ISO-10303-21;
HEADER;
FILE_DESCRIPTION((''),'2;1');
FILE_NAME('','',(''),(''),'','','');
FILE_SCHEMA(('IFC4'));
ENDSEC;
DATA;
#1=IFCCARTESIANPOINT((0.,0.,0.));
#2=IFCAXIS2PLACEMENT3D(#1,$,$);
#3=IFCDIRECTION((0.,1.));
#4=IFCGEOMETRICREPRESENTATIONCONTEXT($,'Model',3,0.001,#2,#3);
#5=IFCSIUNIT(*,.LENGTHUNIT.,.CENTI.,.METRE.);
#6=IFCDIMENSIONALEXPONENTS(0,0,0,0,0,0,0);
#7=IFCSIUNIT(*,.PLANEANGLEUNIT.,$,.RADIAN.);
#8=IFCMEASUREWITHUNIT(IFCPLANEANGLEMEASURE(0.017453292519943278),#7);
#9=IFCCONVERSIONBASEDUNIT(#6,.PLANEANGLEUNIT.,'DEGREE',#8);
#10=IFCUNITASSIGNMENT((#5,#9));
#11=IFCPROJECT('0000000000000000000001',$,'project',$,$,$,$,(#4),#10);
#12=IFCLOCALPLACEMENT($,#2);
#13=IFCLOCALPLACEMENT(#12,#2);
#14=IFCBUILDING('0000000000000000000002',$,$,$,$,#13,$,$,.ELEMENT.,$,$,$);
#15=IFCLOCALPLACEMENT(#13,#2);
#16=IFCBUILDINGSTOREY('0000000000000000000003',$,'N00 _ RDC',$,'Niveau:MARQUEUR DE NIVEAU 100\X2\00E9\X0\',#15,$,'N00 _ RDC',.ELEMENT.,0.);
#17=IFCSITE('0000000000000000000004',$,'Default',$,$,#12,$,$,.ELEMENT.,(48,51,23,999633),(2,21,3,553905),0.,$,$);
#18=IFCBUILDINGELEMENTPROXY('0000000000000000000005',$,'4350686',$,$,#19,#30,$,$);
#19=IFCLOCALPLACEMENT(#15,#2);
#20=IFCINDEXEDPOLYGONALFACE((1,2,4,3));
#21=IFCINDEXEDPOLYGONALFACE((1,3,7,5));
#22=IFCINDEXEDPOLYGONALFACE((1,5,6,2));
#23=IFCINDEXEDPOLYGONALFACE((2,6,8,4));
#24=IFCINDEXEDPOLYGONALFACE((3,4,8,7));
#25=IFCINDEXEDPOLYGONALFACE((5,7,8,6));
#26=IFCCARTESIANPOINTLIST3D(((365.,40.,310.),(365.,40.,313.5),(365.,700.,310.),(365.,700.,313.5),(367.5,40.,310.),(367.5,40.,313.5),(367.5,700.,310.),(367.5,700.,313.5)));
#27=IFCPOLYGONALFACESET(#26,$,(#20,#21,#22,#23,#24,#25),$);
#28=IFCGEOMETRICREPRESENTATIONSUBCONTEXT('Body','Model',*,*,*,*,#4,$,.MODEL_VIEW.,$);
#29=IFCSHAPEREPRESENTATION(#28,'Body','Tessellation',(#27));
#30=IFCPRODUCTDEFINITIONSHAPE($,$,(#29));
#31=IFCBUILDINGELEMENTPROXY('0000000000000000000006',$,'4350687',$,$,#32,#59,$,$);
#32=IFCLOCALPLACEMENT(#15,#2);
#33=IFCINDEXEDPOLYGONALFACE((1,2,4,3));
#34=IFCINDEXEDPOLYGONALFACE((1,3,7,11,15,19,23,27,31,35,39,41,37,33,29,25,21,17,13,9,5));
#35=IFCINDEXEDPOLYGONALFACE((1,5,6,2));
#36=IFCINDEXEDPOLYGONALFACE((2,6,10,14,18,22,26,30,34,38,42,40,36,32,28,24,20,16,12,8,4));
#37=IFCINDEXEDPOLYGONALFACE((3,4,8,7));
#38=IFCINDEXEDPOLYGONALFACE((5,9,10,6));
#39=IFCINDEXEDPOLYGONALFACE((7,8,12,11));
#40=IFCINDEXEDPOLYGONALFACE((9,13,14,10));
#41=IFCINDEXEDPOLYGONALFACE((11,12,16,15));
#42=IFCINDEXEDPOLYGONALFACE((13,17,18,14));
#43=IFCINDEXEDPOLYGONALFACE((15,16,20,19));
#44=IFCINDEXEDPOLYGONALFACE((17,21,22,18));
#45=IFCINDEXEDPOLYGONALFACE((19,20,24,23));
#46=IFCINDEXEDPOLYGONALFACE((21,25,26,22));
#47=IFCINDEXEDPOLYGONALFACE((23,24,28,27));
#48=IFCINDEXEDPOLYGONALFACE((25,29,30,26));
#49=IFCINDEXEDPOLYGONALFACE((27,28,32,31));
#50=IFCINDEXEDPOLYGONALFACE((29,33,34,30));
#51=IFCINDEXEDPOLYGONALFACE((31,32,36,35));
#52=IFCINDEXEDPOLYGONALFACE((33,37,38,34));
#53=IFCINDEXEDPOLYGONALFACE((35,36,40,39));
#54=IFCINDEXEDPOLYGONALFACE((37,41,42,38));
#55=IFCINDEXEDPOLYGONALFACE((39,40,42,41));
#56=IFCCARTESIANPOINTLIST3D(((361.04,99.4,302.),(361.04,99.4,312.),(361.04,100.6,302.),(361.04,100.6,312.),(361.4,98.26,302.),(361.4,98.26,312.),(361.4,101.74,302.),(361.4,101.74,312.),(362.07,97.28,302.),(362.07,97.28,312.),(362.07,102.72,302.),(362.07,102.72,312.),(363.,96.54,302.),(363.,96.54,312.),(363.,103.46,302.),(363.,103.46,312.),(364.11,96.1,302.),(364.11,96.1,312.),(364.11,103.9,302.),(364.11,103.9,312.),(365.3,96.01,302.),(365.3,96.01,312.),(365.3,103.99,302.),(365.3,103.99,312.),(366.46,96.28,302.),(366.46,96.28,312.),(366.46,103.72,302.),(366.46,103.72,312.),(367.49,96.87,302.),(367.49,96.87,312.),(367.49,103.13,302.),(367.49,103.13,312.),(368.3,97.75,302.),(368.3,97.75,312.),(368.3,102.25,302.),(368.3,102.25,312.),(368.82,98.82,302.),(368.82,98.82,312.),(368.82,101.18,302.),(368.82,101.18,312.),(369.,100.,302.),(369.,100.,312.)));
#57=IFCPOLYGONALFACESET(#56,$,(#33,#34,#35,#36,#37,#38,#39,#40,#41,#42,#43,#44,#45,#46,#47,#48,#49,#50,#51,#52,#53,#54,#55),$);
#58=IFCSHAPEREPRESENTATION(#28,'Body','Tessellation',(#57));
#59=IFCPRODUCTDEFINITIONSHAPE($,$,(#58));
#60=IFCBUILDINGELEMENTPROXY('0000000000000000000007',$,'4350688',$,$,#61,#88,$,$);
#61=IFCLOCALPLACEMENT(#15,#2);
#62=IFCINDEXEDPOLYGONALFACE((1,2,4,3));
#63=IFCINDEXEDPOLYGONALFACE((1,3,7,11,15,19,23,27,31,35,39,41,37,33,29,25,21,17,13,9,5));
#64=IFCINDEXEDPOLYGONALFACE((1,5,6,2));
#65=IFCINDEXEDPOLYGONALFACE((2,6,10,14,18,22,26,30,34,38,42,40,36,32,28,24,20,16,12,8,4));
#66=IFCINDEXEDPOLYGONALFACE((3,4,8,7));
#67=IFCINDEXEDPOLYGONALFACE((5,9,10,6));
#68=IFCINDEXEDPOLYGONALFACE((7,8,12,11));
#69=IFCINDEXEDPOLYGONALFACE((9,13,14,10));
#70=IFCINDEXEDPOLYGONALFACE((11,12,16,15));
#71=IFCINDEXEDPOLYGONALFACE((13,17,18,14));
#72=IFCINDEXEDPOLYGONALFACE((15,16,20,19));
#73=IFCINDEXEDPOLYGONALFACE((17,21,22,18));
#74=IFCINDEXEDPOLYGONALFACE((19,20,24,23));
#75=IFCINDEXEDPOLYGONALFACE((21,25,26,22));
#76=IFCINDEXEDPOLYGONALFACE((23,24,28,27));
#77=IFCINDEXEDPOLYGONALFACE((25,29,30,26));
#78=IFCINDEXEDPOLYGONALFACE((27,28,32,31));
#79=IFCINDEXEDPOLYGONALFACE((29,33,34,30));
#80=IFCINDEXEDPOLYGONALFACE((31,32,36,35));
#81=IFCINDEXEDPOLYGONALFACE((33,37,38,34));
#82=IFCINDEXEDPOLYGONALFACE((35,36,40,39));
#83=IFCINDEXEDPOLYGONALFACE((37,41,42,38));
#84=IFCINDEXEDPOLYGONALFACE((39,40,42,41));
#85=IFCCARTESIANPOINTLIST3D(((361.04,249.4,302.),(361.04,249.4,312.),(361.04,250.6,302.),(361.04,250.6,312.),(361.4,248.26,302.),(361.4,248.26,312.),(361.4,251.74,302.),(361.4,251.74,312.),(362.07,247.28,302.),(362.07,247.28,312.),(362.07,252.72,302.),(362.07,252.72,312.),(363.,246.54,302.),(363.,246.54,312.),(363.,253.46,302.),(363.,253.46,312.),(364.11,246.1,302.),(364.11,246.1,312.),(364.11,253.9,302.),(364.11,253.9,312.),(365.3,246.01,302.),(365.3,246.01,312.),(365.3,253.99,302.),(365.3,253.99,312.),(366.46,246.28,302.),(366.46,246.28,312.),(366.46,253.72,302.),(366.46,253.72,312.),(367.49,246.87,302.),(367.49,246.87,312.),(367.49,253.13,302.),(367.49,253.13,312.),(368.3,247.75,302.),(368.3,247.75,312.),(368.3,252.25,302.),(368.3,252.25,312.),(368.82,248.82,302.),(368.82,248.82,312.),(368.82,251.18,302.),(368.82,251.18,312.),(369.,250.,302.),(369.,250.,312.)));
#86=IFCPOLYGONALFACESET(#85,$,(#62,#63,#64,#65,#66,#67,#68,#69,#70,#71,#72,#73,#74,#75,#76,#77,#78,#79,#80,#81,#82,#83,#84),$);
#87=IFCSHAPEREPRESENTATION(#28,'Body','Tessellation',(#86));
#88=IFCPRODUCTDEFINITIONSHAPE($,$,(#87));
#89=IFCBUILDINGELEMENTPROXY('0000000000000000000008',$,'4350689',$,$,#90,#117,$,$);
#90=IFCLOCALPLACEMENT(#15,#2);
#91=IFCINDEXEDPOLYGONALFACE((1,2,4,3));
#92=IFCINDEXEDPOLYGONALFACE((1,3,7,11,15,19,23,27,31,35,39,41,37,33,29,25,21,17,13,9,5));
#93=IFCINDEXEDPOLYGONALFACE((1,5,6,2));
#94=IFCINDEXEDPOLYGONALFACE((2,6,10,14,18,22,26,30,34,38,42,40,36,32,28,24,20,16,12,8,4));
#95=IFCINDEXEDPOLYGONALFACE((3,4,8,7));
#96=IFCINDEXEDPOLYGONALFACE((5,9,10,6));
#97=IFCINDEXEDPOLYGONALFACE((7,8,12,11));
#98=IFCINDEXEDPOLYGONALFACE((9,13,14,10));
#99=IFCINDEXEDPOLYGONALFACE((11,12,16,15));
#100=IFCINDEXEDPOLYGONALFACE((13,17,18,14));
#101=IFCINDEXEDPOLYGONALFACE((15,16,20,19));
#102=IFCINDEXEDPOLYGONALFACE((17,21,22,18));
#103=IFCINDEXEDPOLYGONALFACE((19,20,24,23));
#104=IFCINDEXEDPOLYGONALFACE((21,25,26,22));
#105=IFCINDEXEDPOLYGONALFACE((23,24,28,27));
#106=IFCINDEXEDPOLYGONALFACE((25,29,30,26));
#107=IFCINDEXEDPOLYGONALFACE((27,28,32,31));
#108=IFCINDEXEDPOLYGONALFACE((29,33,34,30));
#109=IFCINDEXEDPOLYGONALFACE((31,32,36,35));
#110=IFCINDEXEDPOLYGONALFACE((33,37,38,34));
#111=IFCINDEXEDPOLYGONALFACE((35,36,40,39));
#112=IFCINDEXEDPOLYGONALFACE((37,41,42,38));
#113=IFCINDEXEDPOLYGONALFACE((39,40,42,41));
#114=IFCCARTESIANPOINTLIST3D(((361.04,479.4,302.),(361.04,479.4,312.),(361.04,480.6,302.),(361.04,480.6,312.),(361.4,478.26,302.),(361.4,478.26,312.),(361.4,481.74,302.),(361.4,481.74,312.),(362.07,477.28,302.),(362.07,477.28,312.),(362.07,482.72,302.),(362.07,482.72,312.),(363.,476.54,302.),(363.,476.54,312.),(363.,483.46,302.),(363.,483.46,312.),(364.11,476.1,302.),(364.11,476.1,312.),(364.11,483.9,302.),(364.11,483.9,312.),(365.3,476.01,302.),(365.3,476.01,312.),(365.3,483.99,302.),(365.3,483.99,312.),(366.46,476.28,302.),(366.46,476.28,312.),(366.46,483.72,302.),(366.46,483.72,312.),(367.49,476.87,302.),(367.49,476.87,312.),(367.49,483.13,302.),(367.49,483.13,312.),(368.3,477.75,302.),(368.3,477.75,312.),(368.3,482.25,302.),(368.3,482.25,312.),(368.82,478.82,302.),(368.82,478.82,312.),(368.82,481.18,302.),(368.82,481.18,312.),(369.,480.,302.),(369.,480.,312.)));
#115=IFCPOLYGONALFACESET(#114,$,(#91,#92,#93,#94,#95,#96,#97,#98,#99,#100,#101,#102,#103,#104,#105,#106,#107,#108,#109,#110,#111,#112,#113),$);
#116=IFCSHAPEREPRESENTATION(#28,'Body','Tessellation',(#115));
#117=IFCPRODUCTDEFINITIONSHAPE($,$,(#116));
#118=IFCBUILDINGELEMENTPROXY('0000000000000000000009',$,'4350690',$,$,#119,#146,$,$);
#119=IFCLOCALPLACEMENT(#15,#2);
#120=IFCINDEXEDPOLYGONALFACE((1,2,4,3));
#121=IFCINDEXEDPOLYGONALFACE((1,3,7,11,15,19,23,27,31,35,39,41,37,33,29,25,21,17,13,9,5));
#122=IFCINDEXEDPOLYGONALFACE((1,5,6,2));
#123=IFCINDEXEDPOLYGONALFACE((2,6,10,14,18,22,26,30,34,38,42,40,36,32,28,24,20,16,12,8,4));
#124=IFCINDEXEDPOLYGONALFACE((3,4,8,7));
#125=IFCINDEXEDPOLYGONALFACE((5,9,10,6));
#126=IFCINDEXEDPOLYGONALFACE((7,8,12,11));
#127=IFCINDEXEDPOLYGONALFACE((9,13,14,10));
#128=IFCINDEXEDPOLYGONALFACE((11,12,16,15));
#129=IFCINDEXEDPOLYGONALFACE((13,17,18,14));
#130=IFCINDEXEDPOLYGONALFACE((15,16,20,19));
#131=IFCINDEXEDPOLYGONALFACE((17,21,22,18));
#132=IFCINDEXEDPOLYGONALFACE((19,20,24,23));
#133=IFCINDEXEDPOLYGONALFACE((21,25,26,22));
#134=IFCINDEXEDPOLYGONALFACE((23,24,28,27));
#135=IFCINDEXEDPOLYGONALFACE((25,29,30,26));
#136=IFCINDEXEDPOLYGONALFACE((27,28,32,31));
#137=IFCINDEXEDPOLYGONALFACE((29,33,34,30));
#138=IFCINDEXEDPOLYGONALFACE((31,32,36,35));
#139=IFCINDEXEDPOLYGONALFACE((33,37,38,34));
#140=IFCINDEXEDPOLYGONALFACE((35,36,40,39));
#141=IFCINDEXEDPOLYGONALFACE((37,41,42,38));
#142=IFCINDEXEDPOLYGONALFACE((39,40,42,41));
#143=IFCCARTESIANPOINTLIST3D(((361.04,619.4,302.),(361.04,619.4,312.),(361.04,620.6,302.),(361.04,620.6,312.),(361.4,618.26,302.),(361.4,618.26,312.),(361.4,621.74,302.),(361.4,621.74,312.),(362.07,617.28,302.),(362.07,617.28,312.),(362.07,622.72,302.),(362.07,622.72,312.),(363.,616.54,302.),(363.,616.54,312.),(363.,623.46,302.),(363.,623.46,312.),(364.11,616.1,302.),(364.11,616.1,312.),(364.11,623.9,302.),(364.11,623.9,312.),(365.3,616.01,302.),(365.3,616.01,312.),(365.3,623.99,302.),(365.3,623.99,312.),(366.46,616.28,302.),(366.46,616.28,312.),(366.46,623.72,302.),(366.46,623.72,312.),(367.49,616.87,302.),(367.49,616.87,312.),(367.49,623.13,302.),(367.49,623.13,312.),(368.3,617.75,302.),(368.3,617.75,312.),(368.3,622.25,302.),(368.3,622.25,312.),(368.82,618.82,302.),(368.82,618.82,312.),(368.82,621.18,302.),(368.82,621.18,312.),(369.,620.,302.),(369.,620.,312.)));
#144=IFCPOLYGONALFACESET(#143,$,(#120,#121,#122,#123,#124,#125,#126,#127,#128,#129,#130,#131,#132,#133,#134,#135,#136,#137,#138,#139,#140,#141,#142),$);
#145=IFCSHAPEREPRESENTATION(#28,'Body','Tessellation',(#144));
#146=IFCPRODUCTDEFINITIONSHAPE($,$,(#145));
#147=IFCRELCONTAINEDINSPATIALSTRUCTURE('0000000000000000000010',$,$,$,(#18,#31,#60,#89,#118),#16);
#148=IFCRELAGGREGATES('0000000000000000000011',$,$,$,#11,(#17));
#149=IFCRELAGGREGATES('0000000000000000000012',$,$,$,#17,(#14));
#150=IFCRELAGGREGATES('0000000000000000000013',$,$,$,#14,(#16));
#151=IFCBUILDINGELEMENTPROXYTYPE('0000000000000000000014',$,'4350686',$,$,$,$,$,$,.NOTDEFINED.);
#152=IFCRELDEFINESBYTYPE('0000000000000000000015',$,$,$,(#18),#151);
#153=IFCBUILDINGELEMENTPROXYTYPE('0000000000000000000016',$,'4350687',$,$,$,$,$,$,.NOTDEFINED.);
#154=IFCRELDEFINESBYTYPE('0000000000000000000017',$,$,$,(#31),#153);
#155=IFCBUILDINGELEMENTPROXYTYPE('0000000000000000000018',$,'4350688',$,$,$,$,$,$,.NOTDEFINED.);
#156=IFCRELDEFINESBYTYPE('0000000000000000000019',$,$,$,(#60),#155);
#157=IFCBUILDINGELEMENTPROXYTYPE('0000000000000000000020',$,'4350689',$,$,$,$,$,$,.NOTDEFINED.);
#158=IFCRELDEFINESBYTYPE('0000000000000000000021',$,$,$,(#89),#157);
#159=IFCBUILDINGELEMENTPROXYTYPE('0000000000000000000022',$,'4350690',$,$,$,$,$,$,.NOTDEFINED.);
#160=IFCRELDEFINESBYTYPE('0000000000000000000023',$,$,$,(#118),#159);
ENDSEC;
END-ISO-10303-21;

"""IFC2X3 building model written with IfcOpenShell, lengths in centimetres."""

from ifc_helpers import new_model, entity, si_unit, converted_unit, direction, frame, frame_2d, origin, origin_2d_with_axis, place, context, subcontext, project, spatial, rectangle, circle, extrude, type_object, element, save


model = new_model("IFC2X3")

# Units and contexts
model_context = context("Model", 3, precision=0.001, world=origin(), true_north=direction((0.0, 1.0)))
body_context = subcontext(model_context, "Body", "Model", "MODEL_VIEW")
ifc_project = project(units=[si_unit("LENGTHUNIT", "METRE", prefix="CENTI"), converted_unit("PLANEANGLEUNIT", "DEGREE", entity("IfcPlaneAngleMeasure", 0.017453292519943278), si_unit("PLANEANGLEUNIT", "RADIAN"), dimensions=[0, 0, 0, 0, 0, 0, 0])], contexts=[model_context])

# Site, building, storey
site_placement = place(None, origin())
site = spatial("IfcSite", under=ifc_project, at=site_placement, Name="Default", CompositionType="ELEMENT", RefLatitude=(48, 51, 23, 999633), RefLongitude=(2, 21, 3, 553905), RefElevation=0.0)
building_placement = place(site_placement, origin())
building = spatial("IfcBuilding", under=site, at=building_placement, CompositionType="ELEMENT")
storey_placement = place(building_placement, origin())
storey = spatial("IfcBuildingStorey", under=building, at=storey_placement, Name="N00 _ RDC", ObjectType="Niveau:MARQUEUR DE NIVEAU 100é", LongName="N00 _ RDC", CompositionType="ELEMENT", Elevation=0.0)

# Building element proxies
building_element_proxy_type_1 = type_object("IfcBuildingElementProxyType", Name="4350686", PredefinedType="NOTDEFINED")
proxy_1_placement = place(storey_placement, origin())
element("IfcBuildingElementProxy", 1, at=proxy_1_placement, inside=storey, type_object=building_element_proxy_type_1, Name="4350686", context=body_context, shape_type="SweptSolid", body=[
    extrude(rectangle(XDim=2.5, YDim=660.0, at=frame_2d((0.0, 0.0), x_axis=(1.0, 0.0))), frame((366.25, 370.0, 310.0)), (0.0, 0.0, 1.0), 3.5),
])
building_element_proxy_type_2 = type_object("IfcBuildingElementProxyType", Name="4350687", PredefinedType="NOTDEFINED")
proxy_2_placement = place(storey_placement, origin())
element("IfcBuildingElementProxy", 2, at=proxy_2_placement, inside=storey, type_object=building_element_proxy_type_2, Name="4350687", context=body_context, shape_type="SweptSolid", body=[
    extrude(circle(Radius=4.0, at=origin_2d_with_axis()), frame((365.0, 100.0, 302.0)), (0.0, 0.0, 1.0), 10.0),
])
building_element_proxy_type_3 = type_object("IfcBuildingElementProxyType", Name="4350688", PredefinedType="NOTDEFINED")
proxy_3_placement = place(storey_placement, origin())
element("IfcBuildingElementProxy", 3, at=proxy_3_placement, inside=storey, type_object=building_element_proxy_type_3, Name="4350688", context=body_context, shape_type="SweptSolid", body=[
    extrude(circle(Radius=4.0, at=origin_2d_with_axis()), frame((365.0, 250.0, 302.0)), (0.0, 0.0, 1.0), 10.0),
])
building_element_proxy_type_4 = type_object("IfcBuildingElementProxyType", Name="4350689", PredefinedType="NOTDEFINED")
proxy_4_placement = place(storey_placement, origin())
element("IfcBuildingElementProxy", 4, at=proxy_4_placement, inside=storey, type_object=building_element_proxy_type_4, Name="4350689", context=body_context, shape_type="SweptSolid", body=[
    extrude(circle(Radius=4.0, at=origin_2d_with_axis()), frame((365.0, 480.0, 302.0)), (0.0, 0.0, 1.0), 10.0),
])
building_element_proxy_type_5 = type_object("IfcBuildingElementProxyType", Name="4350690", PredefinedType="NOTDEFINED")
proxy_5_placement = place(storey_placement, origin())
element("IfcBuildingElementProxy", 5, at=proxy_5_placement, inside=storey, type_object=building_element_proxy_type_5, Name="4350690", context=body_context, shape_type="SweptSolid", body=[
    extrude(circle(Radius=4.0, at=origin_2d_with_axis()), frame((365.0, 620.0, 302.0)), (0.0, 0.0, 1.0), 10.0),
])

save(model, "model.ifc")
